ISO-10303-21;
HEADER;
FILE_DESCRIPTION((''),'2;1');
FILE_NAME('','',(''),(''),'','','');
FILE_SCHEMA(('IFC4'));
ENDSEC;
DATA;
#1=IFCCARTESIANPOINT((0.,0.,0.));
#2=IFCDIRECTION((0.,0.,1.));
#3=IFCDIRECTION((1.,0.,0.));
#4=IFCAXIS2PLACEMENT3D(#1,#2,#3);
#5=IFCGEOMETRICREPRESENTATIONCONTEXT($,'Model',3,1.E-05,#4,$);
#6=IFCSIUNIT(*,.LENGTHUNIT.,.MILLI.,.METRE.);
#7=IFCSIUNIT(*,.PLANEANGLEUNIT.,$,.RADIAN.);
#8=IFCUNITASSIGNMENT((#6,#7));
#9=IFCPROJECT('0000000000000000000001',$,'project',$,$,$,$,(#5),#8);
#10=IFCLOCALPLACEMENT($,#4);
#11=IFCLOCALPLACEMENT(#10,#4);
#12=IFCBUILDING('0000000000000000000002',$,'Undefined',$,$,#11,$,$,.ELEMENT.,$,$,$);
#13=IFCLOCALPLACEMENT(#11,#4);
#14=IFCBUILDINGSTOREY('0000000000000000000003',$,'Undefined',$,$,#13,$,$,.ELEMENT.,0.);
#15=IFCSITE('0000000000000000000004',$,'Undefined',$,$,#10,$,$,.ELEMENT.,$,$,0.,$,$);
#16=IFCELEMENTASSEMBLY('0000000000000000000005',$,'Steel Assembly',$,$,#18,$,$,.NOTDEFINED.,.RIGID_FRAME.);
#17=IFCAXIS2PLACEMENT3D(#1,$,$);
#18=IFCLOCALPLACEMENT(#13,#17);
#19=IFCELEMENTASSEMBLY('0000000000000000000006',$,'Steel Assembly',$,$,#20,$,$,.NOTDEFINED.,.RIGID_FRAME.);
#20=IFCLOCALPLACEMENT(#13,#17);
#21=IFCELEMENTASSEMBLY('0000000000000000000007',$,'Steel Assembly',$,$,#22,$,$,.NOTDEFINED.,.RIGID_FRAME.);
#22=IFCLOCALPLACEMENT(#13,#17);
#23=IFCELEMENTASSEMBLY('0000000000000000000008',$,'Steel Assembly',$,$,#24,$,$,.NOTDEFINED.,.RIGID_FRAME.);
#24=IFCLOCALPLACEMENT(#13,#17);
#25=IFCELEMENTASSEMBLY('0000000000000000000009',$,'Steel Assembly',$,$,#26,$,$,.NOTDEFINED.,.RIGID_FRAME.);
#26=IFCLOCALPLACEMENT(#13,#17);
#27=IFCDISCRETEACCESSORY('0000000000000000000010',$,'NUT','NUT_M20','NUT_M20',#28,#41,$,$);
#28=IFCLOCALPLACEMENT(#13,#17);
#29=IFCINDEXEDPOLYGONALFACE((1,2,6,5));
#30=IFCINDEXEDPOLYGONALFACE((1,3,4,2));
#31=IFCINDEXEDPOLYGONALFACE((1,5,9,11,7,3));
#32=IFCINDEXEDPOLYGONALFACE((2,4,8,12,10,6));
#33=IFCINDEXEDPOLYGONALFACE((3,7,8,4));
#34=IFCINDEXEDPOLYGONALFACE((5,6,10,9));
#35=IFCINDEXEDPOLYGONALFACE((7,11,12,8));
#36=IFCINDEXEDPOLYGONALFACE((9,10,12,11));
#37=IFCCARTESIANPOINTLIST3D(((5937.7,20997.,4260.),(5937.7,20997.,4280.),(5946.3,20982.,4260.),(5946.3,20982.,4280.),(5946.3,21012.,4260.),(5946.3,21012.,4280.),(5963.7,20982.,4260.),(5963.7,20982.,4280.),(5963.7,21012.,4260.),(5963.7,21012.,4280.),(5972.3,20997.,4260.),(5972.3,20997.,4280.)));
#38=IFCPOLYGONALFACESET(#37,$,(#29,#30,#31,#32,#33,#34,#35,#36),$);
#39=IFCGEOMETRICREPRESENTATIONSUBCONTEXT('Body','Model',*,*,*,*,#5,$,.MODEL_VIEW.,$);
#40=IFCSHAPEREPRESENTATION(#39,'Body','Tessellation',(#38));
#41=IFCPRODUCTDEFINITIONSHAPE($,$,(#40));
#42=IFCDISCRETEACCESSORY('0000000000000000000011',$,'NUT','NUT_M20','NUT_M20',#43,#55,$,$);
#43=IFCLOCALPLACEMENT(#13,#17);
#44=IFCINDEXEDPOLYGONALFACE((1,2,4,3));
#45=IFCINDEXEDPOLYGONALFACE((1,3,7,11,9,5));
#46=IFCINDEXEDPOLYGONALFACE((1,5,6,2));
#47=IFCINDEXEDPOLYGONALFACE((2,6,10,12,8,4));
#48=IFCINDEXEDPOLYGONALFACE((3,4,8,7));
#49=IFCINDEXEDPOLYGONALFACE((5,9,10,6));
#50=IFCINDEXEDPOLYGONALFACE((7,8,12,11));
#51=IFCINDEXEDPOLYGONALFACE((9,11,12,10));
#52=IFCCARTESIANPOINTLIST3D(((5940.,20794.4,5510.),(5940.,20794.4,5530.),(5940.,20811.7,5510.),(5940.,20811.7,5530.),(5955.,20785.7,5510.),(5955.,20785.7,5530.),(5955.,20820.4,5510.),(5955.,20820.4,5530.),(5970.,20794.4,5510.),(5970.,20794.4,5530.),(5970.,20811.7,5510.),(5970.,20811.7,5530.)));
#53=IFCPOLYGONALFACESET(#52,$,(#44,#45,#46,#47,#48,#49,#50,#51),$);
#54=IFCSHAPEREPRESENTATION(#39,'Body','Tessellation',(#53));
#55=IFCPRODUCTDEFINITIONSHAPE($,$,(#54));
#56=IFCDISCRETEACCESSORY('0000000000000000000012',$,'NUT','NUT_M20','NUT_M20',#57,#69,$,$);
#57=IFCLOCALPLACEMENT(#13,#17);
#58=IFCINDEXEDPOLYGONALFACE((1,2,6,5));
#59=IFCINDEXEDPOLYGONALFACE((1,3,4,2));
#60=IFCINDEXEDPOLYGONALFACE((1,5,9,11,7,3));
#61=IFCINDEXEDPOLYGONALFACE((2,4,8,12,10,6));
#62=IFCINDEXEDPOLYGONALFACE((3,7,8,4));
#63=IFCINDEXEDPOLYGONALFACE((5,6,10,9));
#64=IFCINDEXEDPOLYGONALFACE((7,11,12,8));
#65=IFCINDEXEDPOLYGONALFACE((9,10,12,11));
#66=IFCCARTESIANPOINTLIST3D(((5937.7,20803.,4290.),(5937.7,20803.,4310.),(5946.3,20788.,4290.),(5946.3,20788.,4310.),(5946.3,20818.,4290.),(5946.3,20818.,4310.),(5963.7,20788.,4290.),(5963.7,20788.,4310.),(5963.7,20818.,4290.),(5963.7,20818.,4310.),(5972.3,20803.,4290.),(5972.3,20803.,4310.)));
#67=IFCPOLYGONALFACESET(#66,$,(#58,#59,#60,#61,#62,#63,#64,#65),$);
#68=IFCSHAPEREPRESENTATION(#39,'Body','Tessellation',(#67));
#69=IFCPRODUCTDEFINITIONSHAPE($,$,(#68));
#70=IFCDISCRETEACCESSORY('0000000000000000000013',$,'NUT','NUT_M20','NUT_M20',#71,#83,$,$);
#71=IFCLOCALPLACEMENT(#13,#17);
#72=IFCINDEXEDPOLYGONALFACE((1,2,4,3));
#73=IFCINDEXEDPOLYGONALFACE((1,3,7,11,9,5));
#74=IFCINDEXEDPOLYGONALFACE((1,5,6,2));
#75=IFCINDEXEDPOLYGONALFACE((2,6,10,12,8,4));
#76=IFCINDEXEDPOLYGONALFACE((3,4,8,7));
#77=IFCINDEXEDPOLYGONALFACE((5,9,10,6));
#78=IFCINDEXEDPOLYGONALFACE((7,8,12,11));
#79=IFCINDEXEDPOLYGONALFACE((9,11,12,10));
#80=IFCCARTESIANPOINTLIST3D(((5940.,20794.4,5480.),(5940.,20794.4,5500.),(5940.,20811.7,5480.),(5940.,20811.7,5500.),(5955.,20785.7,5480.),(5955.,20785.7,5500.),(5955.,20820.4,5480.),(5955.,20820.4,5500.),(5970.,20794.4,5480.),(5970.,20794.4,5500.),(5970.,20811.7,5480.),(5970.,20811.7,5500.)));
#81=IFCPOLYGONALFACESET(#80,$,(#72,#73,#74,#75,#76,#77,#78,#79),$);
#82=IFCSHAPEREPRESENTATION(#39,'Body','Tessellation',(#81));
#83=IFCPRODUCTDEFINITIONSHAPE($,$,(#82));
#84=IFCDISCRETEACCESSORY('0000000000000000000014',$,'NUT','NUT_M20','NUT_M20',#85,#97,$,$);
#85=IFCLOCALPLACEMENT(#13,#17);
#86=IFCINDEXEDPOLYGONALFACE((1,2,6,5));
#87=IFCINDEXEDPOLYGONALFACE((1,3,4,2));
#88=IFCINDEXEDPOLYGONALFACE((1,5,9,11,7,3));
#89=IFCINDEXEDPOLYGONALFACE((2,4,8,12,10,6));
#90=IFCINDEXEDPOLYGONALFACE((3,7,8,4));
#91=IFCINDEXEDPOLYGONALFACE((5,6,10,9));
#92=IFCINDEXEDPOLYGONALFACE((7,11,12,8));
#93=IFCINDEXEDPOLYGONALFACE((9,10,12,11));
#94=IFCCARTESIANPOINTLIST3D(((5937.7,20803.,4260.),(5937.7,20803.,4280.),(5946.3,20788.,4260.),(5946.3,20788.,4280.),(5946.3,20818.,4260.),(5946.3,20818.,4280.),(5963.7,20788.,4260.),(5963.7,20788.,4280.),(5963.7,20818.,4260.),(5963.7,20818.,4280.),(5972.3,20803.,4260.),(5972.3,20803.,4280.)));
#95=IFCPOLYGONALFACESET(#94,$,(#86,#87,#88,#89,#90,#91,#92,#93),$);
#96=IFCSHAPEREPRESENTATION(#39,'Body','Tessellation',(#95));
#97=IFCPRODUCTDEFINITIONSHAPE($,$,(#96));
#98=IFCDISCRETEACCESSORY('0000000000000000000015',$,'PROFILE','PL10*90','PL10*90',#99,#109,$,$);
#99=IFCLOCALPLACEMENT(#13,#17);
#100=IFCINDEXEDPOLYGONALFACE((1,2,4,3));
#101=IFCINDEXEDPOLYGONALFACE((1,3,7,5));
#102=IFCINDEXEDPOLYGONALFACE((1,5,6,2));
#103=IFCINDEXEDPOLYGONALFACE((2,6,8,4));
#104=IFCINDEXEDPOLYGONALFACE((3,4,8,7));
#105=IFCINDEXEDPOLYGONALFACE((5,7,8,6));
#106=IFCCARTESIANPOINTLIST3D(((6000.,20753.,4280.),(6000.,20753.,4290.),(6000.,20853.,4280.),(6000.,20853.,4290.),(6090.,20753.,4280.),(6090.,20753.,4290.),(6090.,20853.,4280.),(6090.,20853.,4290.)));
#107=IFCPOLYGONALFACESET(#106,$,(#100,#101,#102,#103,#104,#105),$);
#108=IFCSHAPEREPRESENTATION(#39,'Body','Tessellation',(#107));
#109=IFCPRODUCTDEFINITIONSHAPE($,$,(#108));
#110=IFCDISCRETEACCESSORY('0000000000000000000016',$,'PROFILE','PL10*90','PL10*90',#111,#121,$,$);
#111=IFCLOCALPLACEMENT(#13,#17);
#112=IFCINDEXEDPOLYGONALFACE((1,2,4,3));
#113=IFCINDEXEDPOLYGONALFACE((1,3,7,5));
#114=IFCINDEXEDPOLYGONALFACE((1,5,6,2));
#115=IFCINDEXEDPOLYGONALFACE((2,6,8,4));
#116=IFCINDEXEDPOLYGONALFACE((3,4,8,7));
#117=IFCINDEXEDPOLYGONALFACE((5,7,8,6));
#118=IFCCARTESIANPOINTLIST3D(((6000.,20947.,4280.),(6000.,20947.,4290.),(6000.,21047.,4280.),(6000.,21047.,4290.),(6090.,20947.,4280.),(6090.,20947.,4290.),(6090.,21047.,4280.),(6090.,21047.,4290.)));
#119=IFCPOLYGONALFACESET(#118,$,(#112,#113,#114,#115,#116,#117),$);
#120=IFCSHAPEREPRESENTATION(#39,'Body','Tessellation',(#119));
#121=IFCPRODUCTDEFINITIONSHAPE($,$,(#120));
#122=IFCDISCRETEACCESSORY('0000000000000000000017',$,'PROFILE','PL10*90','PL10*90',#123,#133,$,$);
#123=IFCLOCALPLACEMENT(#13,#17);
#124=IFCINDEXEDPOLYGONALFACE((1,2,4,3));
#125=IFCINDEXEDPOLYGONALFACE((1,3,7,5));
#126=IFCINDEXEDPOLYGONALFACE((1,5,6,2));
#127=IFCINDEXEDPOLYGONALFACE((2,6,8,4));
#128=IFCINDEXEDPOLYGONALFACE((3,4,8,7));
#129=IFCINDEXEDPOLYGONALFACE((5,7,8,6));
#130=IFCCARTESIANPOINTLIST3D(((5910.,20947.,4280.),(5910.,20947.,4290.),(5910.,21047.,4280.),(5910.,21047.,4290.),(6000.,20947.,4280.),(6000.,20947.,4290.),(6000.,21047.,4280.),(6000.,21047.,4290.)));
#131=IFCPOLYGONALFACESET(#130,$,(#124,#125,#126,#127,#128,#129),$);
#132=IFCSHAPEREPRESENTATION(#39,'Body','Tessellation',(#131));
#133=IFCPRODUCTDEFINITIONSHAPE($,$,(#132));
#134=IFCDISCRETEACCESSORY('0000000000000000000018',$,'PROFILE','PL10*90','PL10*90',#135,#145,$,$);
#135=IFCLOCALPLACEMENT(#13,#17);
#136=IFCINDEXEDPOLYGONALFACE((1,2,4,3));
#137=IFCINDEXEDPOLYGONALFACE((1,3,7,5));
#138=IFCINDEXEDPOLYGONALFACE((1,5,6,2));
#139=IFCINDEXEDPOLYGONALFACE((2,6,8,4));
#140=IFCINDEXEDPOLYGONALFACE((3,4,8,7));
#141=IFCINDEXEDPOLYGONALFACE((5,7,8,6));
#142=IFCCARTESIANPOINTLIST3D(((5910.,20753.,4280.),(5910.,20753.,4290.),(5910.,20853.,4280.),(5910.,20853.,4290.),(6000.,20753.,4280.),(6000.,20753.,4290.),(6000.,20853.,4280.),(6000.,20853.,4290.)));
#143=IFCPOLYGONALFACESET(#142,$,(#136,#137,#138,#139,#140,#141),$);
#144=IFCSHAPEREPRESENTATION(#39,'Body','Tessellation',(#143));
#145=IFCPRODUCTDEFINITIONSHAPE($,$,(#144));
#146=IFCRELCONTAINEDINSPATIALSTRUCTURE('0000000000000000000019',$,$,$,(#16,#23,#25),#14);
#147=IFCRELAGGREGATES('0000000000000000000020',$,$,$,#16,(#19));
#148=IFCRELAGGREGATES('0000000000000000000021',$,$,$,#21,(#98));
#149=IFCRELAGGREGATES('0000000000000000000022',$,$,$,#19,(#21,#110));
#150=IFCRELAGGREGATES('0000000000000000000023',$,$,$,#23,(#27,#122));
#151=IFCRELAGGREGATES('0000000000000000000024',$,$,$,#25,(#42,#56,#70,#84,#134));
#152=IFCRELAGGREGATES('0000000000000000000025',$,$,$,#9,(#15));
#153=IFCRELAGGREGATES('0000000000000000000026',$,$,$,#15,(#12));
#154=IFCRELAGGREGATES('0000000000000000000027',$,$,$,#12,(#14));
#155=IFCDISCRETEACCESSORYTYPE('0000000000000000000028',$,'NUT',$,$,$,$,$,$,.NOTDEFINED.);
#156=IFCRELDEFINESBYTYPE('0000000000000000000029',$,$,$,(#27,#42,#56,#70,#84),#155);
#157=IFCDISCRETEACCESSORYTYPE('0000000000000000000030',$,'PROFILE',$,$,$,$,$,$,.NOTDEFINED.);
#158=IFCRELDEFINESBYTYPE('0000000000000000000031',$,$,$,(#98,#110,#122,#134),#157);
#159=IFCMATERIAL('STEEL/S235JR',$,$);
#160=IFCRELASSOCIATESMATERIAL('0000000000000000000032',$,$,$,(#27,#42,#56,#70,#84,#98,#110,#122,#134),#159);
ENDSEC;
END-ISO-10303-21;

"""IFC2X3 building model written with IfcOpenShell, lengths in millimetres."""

from ifc_helpers import new_model, si_unit, frame, origin_with_axes, place, context, subcontext, project, spatial, polyline, outline, extrude, material, type_object, element, aggregate, save


model = new_model("IFC2X3")

# Units and contexts
model_context = context("Model", 3, precision=1e-05, world=origin_with_axes())
body_context = subcontext(model_context, "Body", "Model", "MODEL_VIEW")
ifc_project = project(units=[si_unit("LENGTHUNIT", "METRE", prefix="MILLI"), si_unit("PLANEANGLEUNIT", "RADIAN")], contexts=[model_context])

# Site, building, storey
site_placement = place(None, origin_with_axes())
site = spatial("IfcSite", under=ifc_project, at=site_placement, Name="Undefined", CompositionType="ELEMENT", RefElevation=0.0)
building_placement = place(site_placement, origin_with_axes())
building = spatial("IfcBuilding", under=site, at=building_placement, Name="Undefined", CompositionType="ELEMENT")
storey_placement = place(building_placement, origin_with_axes())
storey = spatial("IfcBuildingStorey", under=building, at=storey_placement, Name="Undefined", CompositionType="ELEMENT", Elevation=0.0)

# Element assemblies
assembly_1_placement = place(storey_placement, origin_with_axes())
assembly_1 = element("IfcElementAssembly", 1, at=assembly_1_placement, inside=storey, Name="Steel Assembly", AssemblyPlace="NOTDEFINED", PredefinedType="RIGID_FRAME")
assembly_2_placement = place(assembly_1_placement, origin_with_axes())
assembly_2 = element("IfcElementAssembly", 2, at=assembly_2_placement, Name="Steel Assembly", AssemblyPlace="NOTDEFINED", PredefinedType="RIGID_FRAME")
assembly_3_placement = place(assembly_2_placement, origin_with_axes())
assembly_3 = element("IfcElementAssembly", 3, at=assembly_3_placement, Name="Steel Assembly", AssemblyPlace="NOTDEFINED", PredefinedType="RIGID_FRAME")

# Element assemblies
assembly_4_placement = place(storey_placement, origin_with_axes())
assembly_4 = element("IfcElementAssembly", 4, at=assembly_4_placement, inside=storey, Name="Steel Assembly", AssemblyPlace="NOTDEFINED", PredefinedType="RIGID_FRAME")
assembly_5_placement = place(storey_placement, origin_with_axes())
assembly_5 = element("IfcElementAssembly", 5, at=assembly_5_placement, inside=storey, Name="Steel Assembly", AssemblyPlace="NOTDEFINED", PredefinedType="RIGID_FRAME")

# Shared definitions
ifc_material_1 = material(Name="STEEL/S235JR")

aggregate(assembly_1, [assembly_2])

# Discrete accessories
discrete_accessory_type_1 = type_object("IfcDiscreteAccessoryType", Name="NUT")
discrete_accessory_1_placement = place(assembly_4_placement, frame((5955.0, 20997.0, 4280.0), z_axis=(0.0, 1.0, 0.0), x_axis=(0.0, 0.0, -1.0)))
discrete_accessory_1 = element("IfcDiscreteAccessory", 6, at=discrete_accessory_1_placement, type_object=discrete_accessory_type_1, material=ifc_material_1, Name="NUT", Description="NUT_M20", ObjectType="NUT_M20", context=body_context, shape_type="SweptSolid", body=[
    extrude(outline(polyline([(8.7, 15.0), (17.3, 0.0), (8.7, -15.0), (-8.7, -15.0), (-17.3, 0.0), (-8.7, 15.0), (8.7, 15.0)])), frame((20.0, 0.0, 0.0), z_axis=(-1.0, 0.0, 0.0), x_axis=(0.0, -1.0, 0.0)), (0.0, 0.0, 1.0), 20.0),
])
discrete_accessory_2_placement = place(assembly_5_placement, frame((5955.0, 20803.0, 5530.0), z_axis=(-1.0, 0.0, 0.0), x_axis=(0.0, 0.0, -1.0)))
discrete_accessory_2 = element("IfcDiscreteAccessory", 7, at=discrete_accessory_2_placement, type_object=discrete_accessory_type_1, material=ifc_material_1, Name="NUT", Description="NUT_M20", ObjectType="NUT_M20", context=body_context, shape_type="SweptSolid", body=[
    extrude(outline(polyline([(8.7, 15.0), (17.3, 0.0), (8.7, -15.0), (-8.7, -15.0), (-17.3, 0.0), (-8.7, 15.0), (8.7, 15.0)])), frame((20.0, 0.0, 0.0), z_axis=(-1.0, 0.0, 0.0), x_axis=(0.0, -1.0, 0.0)), (0.0, 0.0, 1.0), 20.0),
])
discrete_accessory_3_placement = place(assembly_5_placement, frame((5955.0, 20803.0, 4310.0), z_axis=(0.0, -1.0, 0.0), x_axis=(0.0, 0.0, -1.0)))
discrete_accessory_3 = element("IfcDiscreteAccessory", 8, at=discrete_accessory_3_placement, type_object=discrete_accessory_type_1, material=ifc_material_1, Name="NUT", Description="NUT_M20", ObjectType="NUT_M20", context=body_context, shape_type="SweptSolid", body=[
    extrude(outline(polyline([(8.7, 15.0), (17.3, 0.0), (8.7, -15.0), (-8.7, -15.0), (-17.3, 0.0), (-8.7, 15.0), (8.7, 15.0)])), frame((20.0, 0.0, 0.0), z_axis=(-1.0, 0.0, 0.0), x_axis=(0.0, -1.0, 0.0)), (0.0, 0.0, 1.0), 20.0),
])
discrete_accessory_4_placement = place(assembly_5_placement, frame((5955.0, 20803.0, 5500.0), z_axis=(-1.0, 0.0, 0.0), x_axis=(0.0, 0.0, -1.0)))
discrete_accessory_4 = element("IfcDiscreteAccessory", 9, at=discrete_accessory_4_placement, type_object=discrete_accessory_type_1, material=ifc_material_1, Name="NUT", Description="NUT_M20", ObjectType="NUT_M20", context=body_context, shape_type="SweptSolid", body=[
    extrude(outline(polyline([(8.7, 15.0), (17.3, 0.0), (8.7, -15.0), (-8.7, -15.0), (-17.3, 0.0), (-8.7, 15.0), (8.7, 15.0)])), frame((20.0, 0.0, 0.0), z_axis=(-1.0, 0.0, 0.0), x_axis=(0.0, -1.0, 0.0)), (0.0, 0.0, 1.0), 20.0),
])
discrete_accessory_5_placement = place(assembly_5_placement, frame((5955.0, 20803.0, 4280.0), z_axis=(0.0, -1.0, 0.0), x_axis=(0.0, 0.0, -1.0)))
discrete_accessory_5 = element("IfcDiscreteAccessory", 10, at=discrete_accessory_5_placement, type_object=discrete_accessory_type_1, material=ifc_material_1, Name="NUT", Description="NUT_M20", ObjectType="NUT_M20", context=body_context, shape_type="SweptSolid", body=[
    extrude(outline(polyline([(8.7, 15.0), (17.3, 0.0), (8.7, -15.0), (-8.7, -15.0), (-17.3, 0.0), (-8.7, 15.0), (8.7, 15.0)])), frame((20.0, 0.0, 0.0), z_axis=(-1.0, 0.0, 0.0), x_axis=(0.0, -1.0, 0.0)), (0.0, 0.0, 1.0), 20.0),
])
discrete_accessory_type_2 = type_object("IfcDiscreteAccessoryType", Name="PROFILE")
discrete_accessory_6_placement = place(assembly_3_placement, frame((6045.0, 20853.0, 4285.0), z_axis=(0.0, 0.0, 1.0), x_axis=(0.0, -1.0, 0.0)))
discrete_accessory_6 = element("IfcDiscreteAccessory", 11, at=discrete_accessory_6_placement, type_object=discrete_accessory_type_2, material=ifc_material_1, Name="PROFILE", Description="PL10*90", ObjectType="PL10*90", context=body_context, shape_type="SweptSolid", body=[
    extrude(outline(polyline([(100.0, -45.0), (0.0, -45.0), (0.0, 45.0), (100.0, 45.0), (100.0, -45.0)])), frame((0.0, 0.0, -5.0), z_axis=(0.0, 0.0, 1.0), x_axis=(1.0, 0.0, 0.0)), (0.0, 0.0, 1.0), 10.0),
])
aggregate(assembly_3, [discrete_accessory_6])
discrete_accessory_7_placement = place(assembly_2_placement, frame((6045.0, 20947.0, 4285.0), z_axis=(0.0, 0.0, -1.0), x_axis=(0.0, 1.0, 0.0)))
discrete_accessory_7 = element("IfcDiscreteAccessory", 12, at=discrete_accessory_7_placement, type_object=discrete_accessory_type_2, material=ifc_material_1, Name="PROFILE", Description="PL10*90", ObjectType="PL10*90", context=body_context, shape_type="SweptSolid", body=[
    extrude(outline(polyline([(0.0, -45.0), (0.0, 45.0), (100.0, 45.0), (100.0, -45.0), (0.0, -45.0)])), frame((0.0, 0.0, -5.0), z_axis=(0.0, 0.0, 1.0), x_axis=(1.0, 0.0, 0.0)), (0.0, 0.0, 1.0), 10.0),
])
aggregate(assembly_2, [assembly_3, discrete_accessory_7])
discrete_accessory_8_placement = place(assembly_4_placement, frame((5955.0, 20947.0, 4285.0), z_axis=(0.0, 0.0, -1.0), x_axis=(0.0, 1.0, 0.0)))
discrete_accessory_8 = element("IfcDiscreteAccessory", 13, at=discrete_accessory_8_placement, type_object=discrete_accessory_type_2, material=ifc_material_1, Name="PROFILE", Description="PL10*90", ObjectType="PL10*90", context=body_context, shape_type="SweptSolid", body=[
    extrude(outline(polyline([(0.0, -45.0), (0.0, 45.0), (100.0, 45.0), (100.0, -45.0), (0.0, -45.0)])), frame((0.0, 0.0, -5.0), z_axis=(0.0, 0.0, 1.0), x_axis=(1.0, 0.0, 0.0)), (0.0, 0.0, 1.0), 10.0),
])
aggregate(assembly_4, [discrete_accessory_1, discrete_accessory_8])
discrete_accessory_9_placement = place(assembly_5_placement, frame((5955.0, 20853.0, 4285.0), z_axis=(0.0, 0.0, 1.0), x_axis=(0.0, -1.0, 0.0)))
discrete_accessory_9 = element("IfcDiscreteAccessory", 14, at=discrete_accessory_9_placement, type_object=discrete_accessory_type_2, material=ifc_material_1, Name="PROFILE", Description="PL10*90", ObjectType="PL10*90", context=body_context, shape_type="SweptSolid", body=[
    extrude(outline(polyline([(100.0, -45.0), (0.0, -45.0), (0.0, 45.0), (100.0, 45.0), (100.0, -45.0)])), frame((0.0, 0.0, -5.0), z_axis=(0.0, 0.0, 1.0), x_axis=(1.0, 0.0, 0.0)), (0.0, 0.0, 1.0), 10.0),
])
aggregate(assembly_5, [discrete_accessory_2, discrete_accessory_3, discrete_accessory_4, discrete_accessory_5, discrete_accessory_9])

save(model, "model.ifc")
